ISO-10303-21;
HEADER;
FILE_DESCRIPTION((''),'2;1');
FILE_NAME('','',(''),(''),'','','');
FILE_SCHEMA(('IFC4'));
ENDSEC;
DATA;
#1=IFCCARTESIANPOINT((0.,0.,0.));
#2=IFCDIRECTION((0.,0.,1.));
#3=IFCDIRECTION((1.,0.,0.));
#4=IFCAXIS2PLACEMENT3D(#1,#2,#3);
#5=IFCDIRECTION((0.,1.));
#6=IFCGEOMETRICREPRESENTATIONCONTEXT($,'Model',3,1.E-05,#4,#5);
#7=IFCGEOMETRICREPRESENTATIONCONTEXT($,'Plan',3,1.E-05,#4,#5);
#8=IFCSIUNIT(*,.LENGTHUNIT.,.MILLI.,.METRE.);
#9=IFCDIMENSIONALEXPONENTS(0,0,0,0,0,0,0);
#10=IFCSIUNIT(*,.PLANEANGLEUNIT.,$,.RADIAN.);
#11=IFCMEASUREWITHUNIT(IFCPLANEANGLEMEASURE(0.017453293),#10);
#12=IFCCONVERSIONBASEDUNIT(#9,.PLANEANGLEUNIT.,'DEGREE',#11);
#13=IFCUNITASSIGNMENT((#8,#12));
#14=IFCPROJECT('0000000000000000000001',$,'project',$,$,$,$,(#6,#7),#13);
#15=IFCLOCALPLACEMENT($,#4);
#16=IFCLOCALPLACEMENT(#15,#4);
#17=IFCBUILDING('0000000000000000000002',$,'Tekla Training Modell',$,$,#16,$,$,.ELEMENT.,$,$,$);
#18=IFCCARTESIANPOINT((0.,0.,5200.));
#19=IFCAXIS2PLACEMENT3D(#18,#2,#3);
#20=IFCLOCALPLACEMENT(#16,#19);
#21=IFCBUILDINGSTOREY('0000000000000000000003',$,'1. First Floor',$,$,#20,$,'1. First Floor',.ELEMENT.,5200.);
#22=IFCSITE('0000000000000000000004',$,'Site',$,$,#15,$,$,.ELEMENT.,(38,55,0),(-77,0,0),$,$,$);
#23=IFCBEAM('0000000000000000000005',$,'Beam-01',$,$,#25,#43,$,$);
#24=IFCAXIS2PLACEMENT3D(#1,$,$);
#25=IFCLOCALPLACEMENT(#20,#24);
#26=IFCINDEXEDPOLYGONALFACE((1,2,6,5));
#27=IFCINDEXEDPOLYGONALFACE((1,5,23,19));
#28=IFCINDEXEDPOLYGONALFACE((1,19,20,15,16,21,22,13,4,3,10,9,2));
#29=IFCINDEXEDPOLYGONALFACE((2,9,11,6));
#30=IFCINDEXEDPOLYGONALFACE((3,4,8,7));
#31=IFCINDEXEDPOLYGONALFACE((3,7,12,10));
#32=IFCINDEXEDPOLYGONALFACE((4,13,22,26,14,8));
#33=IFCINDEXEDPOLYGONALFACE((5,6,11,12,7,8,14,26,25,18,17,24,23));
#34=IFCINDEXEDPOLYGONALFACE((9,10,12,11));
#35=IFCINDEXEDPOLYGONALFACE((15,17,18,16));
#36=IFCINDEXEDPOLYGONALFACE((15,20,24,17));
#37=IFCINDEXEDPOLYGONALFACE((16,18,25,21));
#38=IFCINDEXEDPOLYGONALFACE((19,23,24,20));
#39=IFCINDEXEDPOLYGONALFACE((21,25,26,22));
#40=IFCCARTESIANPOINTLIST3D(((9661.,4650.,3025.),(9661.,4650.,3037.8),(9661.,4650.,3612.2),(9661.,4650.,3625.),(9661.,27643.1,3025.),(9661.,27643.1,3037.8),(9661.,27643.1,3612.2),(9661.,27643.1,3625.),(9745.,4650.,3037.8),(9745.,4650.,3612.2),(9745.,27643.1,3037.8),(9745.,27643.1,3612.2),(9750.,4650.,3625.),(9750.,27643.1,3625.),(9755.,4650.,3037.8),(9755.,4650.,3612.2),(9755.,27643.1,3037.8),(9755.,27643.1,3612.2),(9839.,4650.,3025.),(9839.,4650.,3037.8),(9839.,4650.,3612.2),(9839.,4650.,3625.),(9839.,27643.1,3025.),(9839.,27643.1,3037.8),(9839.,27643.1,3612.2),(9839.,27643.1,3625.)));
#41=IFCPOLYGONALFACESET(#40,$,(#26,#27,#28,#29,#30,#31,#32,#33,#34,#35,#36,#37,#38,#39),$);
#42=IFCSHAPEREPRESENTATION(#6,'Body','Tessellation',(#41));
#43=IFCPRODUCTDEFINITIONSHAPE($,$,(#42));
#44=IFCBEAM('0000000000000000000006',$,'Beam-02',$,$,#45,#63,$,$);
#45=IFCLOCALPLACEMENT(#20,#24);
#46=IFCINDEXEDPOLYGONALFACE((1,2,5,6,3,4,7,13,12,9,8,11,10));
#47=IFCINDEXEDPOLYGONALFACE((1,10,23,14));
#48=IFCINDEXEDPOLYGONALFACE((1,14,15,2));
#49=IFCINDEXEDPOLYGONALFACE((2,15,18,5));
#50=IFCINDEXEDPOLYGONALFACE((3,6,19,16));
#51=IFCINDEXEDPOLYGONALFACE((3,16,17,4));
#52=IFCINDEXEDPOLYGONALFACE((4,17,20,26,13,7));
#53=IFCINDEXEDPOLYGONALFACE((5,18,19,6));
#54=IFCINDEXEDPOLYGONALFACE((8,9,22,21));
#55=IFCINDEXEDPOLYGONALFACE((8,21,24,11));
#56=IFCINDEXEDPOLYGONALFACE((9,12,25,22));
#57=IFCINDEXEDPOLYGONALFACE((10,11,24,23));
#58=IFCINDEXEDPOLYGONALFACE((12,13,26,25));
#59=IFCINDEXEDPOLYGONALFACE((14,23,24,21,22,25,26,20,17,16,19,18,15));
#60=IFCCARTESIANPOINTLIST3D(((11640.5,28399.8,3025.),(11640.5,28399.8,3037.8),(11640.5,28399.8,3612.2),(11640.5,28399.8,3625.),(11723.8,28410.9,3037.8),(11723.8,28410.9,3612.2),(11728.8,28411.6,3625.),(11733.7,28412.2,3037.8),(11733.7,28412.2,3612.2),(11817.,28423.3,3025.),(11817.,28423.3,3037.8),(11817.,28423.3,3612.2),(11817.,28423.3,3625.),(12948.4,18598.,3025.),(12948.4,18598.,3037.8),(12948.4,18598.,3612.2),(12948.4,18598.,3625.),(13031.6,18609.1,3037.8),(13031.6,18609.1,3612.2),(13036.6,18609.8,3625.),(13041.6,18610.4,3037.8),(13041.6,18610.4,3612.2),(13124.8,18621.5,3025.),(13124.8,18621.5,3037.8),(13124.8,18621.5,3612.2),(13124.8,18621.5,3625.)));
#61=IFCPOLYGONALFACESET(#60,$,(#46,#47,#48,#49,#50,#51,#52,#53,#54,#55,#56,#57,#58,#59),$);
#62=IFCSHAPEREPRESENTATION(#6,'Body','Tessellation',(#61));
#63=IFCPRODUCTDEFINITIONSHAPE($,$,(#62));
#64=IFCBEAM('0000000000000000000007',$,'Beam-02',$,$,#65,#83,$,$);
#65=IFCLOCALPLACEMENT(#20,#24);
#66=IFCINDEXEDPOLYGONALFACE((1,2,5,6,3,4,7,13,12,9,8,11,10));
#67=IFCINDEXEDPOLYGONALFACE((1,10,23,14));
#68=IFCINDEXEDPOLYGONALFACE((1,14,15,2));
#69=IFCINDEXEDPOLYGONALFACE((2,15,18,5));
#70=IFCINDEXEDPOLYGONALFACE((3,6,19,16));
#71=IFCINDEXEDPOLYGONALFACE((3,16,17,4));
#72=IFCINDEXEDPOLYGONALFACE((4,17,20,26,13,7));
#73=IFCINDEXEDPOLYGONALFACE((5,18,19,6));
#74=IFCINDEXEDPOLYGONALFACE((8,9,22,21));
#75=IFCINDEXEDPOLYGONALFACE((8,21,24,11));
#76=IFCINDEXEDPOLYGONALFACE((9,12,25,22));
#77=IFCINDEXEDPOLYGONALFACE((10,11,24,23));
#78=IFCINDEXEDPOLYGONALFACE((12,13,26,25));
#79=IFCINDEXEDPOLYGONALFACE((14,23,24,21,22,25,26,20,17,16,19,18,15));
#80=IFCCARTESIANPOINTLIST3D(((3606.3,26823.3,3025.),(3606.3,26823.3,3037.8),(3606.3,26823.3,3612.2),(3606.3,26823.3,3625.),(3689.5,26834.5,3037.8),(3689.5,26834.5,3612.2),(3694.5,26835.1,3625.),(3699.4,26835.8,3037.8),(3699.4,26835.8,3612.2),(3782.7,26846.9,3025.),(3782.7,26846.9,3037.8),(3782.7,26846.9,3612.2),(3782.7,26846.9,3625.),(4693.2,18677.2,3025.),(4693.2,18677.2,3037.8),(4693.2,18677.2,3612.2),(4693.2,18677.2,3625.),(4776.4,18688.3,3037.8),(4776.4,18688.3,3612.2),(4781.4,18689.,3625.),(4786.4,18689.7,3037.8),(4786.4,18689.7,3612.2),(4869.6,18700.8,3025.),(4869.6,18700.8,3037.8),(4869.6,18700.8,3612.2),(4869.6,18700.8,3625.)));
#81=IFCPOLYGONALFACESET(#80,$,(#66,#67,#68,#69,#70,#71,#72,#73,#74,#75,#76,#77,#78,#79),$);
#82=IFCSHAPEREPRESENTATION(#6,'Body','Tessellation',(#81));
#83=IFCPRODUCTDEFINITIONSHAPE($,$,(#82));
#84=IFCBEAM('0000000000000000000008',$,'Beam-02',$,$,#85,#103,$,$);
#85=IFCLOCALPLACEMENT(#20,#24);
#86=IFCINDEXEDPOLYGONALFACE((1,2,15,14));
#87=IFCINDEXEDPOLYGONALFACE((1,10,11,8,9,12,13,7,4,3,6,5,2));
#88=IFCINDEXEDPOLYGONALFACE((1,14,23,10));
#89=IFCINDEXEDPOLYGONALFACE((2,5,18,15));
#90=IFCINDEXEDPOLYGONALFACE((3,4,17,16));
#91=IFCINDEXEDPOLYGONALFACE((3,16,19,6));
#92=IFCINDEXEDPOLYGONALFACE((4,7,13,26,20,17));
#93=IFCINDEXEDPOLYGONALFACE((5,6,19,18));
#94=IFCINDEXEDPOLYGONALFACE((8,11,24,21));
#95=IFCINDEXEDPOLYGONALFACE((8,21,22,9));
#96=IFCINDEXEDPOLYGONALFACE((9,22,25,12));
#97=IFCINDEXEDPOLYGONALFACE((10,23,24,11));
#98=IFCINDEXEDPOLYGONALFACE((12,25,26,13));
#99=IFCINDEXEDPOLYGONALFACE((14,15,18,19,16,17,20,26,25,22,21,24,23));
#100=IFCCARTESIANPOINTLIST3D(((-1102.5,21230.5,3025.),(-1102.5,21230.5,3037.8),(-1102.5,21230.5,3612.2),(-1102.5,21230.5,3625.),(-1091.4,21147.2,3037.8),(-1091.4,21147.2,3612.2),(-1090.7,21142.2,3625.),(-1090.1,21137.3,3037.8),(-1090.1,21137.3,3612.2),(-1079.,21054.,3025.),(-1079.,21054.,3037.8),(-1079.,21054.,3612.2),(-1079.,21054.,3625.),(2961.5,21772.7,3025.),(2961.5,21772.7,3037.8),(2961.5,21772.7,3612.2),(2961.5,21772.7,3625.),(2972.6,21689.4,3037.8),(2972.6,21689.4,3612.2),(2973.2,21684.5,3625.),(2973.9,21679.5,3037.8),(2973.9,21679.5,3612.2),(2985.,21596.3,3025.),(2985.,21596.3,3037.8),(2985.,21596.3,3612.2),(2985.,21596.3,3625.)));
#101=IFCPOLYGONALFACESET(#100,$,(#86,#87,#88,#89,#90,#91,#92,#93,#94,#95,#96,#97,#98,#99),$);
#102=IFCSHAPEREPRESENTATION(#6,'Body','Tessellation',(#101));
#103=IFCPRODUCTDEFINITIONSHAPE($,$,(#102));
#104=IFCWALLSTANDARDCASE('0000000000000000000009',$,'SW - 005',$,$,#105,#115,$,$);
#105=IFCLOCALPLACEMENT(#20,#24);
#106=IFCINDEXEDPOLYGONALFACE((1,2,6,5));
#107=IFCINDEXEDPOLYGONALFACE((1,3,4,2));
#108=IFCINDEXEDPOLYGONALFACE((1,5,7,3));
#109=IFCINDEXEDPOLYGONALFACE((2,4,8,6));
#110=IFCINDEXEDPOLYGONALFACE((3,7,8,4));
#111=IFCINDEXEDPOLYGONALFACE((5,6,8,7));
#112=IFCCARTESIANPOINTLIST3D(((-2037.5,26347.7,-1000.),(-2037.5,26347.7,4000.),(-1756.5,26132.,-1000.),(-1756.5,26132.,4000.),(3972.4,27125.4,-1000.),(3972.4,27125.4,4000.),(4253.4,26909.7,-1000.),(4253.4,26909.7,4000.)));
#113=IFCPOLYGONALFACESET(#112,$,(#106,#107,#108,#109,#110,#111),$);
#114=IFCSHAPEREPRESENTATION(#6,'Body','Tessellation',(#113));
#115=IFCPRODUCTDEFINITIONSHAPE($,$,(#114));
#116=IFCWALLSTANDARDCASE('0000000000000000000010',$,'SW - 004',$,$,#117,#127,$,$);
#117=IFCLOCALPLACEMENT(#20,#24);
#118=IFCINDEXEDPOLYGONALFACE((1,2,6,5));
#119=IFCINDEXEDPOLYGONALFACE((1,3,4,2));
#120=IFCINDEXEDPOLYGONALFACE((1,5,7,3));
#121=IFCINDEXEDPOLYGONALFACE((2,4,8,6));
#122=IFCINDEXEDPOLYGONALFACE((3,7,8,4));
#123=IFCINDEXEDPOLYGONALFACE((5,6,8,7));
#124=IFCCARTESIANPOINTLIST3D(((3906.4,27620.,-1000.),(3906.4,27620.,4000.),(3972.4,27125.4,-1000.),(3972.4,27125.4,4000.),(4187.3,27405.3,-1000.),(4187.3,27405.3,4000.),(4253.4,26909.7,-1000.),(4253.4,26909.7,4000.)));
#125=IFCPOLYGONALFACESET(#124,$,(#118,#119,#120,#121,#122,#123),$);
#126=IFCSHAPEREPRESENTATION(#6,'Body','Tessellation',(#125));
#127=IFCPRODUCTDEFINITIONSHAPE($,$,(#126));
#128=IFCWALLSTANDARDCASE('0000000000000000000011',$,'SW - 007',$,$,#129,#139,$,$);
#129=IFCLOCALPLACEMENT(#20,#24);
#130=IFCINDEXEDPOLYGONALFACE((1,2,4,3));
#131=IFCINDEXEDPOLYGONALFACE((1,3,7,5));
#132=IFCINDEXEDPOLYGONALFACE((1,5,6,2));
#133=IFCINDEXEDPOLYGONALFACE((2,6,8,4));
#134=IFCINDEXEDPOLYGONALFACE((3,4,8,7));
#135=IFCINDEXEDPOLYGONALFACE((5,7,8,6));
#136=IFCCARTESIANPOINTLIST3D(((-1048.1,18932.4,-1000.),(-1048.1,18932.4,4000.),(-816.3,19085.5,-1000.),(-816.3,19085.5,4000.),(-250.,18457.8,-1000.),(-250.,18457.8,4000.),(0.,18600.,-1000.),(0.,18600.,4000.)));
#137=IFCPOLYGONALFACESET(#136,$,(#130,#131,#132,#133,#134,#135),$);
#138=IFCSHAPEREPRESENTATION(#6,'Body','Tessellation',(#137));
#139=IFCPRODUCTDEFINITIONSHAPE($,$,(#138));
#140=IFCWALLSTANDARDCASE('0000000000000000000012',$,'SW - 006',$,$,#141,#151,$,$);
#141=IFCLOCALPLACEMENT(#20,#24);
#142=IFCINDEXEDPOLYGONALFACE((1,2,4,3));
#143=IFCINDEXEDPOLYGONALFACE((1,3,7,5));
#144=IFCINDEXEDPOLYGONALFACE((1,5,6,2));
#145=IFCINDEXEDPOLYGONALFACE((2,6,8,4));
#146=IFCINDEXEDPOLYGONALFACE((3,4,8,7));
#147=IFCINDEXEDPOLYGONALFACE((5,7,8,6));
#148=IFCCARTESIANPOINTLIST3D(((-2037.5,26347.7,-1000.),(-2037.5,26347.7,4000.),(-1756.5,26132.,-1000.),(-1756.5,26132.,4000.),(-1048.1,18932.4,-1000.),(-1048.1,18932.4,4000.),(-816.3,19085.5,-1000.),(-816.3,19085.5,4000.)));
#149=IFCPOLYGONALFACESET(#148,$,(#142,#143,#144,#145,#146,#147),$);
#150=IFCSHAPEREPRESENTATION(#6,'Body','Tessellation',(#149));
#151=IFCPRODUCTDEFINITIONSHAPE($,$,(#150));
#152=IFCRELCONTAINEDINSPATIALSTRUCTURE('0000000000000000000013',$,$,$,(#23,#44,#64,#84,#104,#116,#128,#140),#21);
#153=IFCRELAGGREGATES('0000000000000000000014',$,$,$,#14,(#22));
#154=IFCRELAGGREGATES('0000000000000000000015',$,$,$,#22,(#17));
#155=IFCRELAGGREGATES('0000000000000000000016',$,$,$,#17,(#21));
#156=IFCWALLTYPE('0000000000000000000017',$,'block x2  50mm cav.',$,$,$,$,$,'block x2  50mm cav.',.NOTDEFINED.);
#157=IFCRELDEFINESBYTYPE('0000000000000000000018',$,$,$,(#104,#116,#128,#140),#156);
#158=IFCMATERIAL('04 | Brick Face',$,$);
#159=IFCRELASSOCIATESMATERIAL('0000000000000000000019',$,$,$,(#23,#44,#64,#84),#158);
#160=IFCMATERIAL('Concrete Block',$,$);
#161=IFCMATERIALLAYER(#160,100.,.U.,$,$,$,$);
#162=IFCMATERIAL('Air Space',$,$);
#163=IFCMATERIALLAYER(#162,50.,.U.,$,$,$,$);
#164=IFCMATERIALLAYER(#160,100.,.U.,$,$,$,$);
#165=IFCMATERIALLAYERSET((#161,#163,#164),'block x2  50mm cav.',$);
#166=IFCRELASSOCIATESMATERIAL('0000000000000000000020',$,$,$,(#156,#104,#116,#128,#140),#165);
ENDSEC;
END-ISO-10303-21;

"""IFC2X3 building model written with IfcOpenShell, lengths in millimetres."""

from ifc_helpers import new_model, entity, si_unit, converted_unit, direction, frame, origin_with_axes, place, context, project, spatial, polyline, outline, extrude, material, layer, layer_set, layer_usage, type_object, element, save


model = new_model("IFC2X3")

# Units and contexts
model_context = context("Model", 3, precision=1e-05, world=origin_with_axes(), true_north=direction((0.0, 1.0)))
plan_context = context("Plan", 3, precision=1e-05, world=origin_with_axes(), true_north=direction((0.0, 1.0)))
ifc_project = project(units=[si_unit("LENGTHUNIT", "METRE", prefix="MILLI"), converted_unit("PLANEANGLEUNIT", "DEGREE", entity("IfcPlaneAngleMeasure", 0.017453293), si_unit("PLANEANGLEUNIT", "RADIAN"), dimensions=[0, 0, 0, 0, 0, 0, 0])], contexts=[model_context, plan_context])

# Site, building, storey
site_placement = place(None, origin_with_axes())
site = spatial("IfcSite", under=ifc_project, at=site_placement, Name="Site", CompositionType="ELEMENT", RefLatitude=(38, 55, 0), RefLongitude=(-77, 0, 0))
building_placement = place(site_placement, origin_with_axes())
building = spatial("IfcBuilding", under=site, at=building_placement, Name="Tekla Training Modell", CompositionType="ELEMENT")
storey_placement = place(building_placement, frame((0.0, 0.0, 5200.0), z_axis=(0.0, 0.0, 1.0), x_axis=(1.0, 0.0, 0.0)))
storey = spatial("IfcBuildingStorey", under=building, at=storey_placement, Name="1. First Floor", LongName="1. First Floor", CompositionType="ELEMENT", Elevation=5200.0)

# Shared definitions
ifc_material_1 = material(Name="04 | Brick Face")

# Beams
beam_1_placement = place(storey_placement, frame((9750.0, 27643.1, 3325.0), z_axis=(0.0, 0.0, 1.0), x_axis=(-1.0, 0.0, 0.0)))
element("IfcBeam", 1, at=beam_1_placement, inside=storey, material=ifc_material_1, Name="Beam-01", context=model_context, shape_type="SweptSolid", body=[
    extrude(outline(polyline([(0.0, 300.0), (-89.0, 300.0), (-89.0, 287.2), (-5.0, 287.2), (-5.0, -287.2), (-89.0, -287.2), (-89.0, -300.0), (89.0, -300.0), (89.0, -287.2), (5.0, -287.2), (5.0, 287.2), (89.0, 287.2), (89.0, 300.0), (0.0, 300.0)])), frame((0.0, 22993.1, 0.0), z_axis=(0.0, -1.0, 0.0), x_axis=(1.0, 0.0, 0.0)), (0.0, 0.0, 1.0), 22993.1),
])
beam_2_placement = place(storey_placement, frame((11728.8, 28411.6, 3325.0), z_axis=(0.0, 0.0, 1.0), x_axis=(-0.991216, -0.132256, 0.0)))
element("IfcBeam", 2, at=beam_2_placement, inside=storey, material=ifc_material_1, Name="Beam-02", context=model_context, shape_type="SweptSolid", body=[
    extrude(outline(polyline([(0.0, 300.0), (-89.0, 300.0), (-89.0, 287.2), (-5.0, 287.2), (-5.0, -287.2), (-89.0, -287.2), (-89.0, -300.0), (89.0, -300.0), (89.0, -287.2), (5.0, -287.2), (5.0, 287.2), (89.0, 287.2), (89.0, 300.0), (0.0, 300.0)])), frame((0.0, 9888.6, 0.0), z_axis=(0.0, -1.0, 0.0), x_axis=(1.0, 0.0, 0.0)), (0.0, 0.0, 1.0), 9888.6),
])
beam_3_placement = place(storey_placement, frame((3694.5, 26835.1, 3325.0), z_axis=(0.0, 0.0, 1.0), x_axis=(-0.991216, -0.132256, 0.0)))
element("IfcBeam", 3, at=beam_3_placement, inside=storey, material=ifc_material_1, Name="Beam-02", context=model_context, shape_type="SweptSolid", body=[
    extrude(outline(polyline([(0.0, 300.0), (-89.0, 300.0), (-89.0, 287.2), (-5.0, 287.2), (-5.0, -287.2), (-89.0, -287.2), (-89.0, -300.0), (89.0, -300.0), (89.0, -287.2), (5.0, -287.2), (5.0, 287.2), (89.0, 287.2), (89.0, 300.0), (0.0, 300.0)])), frame((0.0, 8218.3, 0.0), z_axis=(0.0, -1.0, 0.0), x_axis=(1.0, 0.0, 0.0)), (0.0, 0.0, 1.0), 8218.3),
])
beam_4_placement = place(storey_placement, frame((-1090.7, 21142.2, 3325.0), z_axis=(0.0, 0.0, 1.0), x_axis=(0.132256, -0.991216, 0.0)))
element("IfcBeam", 4, at=beam_4_placement, inside=storey, material=ifc_material_1, Name="Beam-02", context=model_context, shape_type="SweptSolid", body=[
    extrude(outline(polyline([(0.0, 300.0), (-89.0, 300.0), (-89.0, 287.2), (-5.0, 287.2), (-5.0, -287.2), (-89.0, -287.2), (-89.0, -300.0), (89.0, -300.0), (89.0, -287.2), (5.0, -287.2), (5.0, 287.2), (89.0, 287.2), (89.0, 300.0), (0.0, 300.0)])), frame((0.0, 4100.0, 0.0), z_axis=(0.0, -1.0, 0.0), x_axis=(1.0, 0.0, 0.0)), (0.0, 0.0, 1.0), 4100.0),
])

# Walls
ifc_material_2 = material(Name="Concrete Block")
ifc_layer_1 = layer(ifc_material_2, 100.0, ventilated="UNKNOWN")
ifc_material_3 = material(Name="Air Space")
ifc_layer_2 = layer(ifc_material_3, 50.0, ventilated="UNKNOWN")
ifc_layer_3 = layer(ifc_material_2, 100.0, ventilated="UNKNOWN")
ifc_layer_set_1 = layer_set([ifc_layer_1, ifc_layer_2, ifc_layer_3], Name="block x2  50mm cav.")
ifc_layer_usage_1 = layer_usage(ifc_layer_set_1, "AXIS2", "NEGATIVE", 0.0)
wall_type = type_object("IfcWallType", Name="block x2  50mm cav.", ElementType="block x2  50mm cav.", PredefinedType="NOTDEFINED", material=ifc_layer_set_1)
wall_1_placement = place(storey_placement, frame((4253.4, 26909.7, -1000.0), z_axis=(0.0, 0.0, 1.0), x_axis=(-0.991732, -0.12833, 0.0)))
element("IfcWallStandardCase", 5, at=wall_1_placement, inside=storey, type_object=wall_type, material=ifc_layer_usage_1, Name="SW - 005", context=model_context, shape_type="SweptSolid", body=[
    extrude(outline(polyline([(251.0, -250.0), (6311.0, -250.0), (6060.0, 0.0), (0.0, 0.0), (251.0, -250.0)])), origin_with_axes(), (0.0, 0.0, 1.0), 5000.0),
])
ifc_layer_usage_2 = layer_usage(ifc_layer_set_1, "AXIS2", "NEGATIVE", 0.0)
wall_2_placement = place(storey_placement, frame((4187.3, 27405.3, -1000.0), z_axis=(0.0, 0.0, 1.0), x_axis=(0.132257, -0.991215, 0.0)))
element("IfcWallStandardCase", 6, at=wall_2_placement, inside=storey, type_object=wall_type, material=ifc_layer_usage_2, Name="SW - 004", context=model_context, shape_type="SweptSolid", body=[
    extrude(outline(polyline([(-250.0, -250.0), (249.0, -250.0), (500.0, 0.0), (0.0, 0.0), (-250.0, -250.0)])), origin_with_axes(), (0.0, 0.0, 1.0), 5000.0),
])
ifc_layer_usage_3 = layer_usage(ifc_layer_set_1, "AXIS2", "NEGATIVE", 0.0)
wall_3_placement = place(storey_placement, frame((-816.3, 19085.5, -1000.0), z_axis=(0.0, 0.0, 1.0), x_axis=(0.859493, -0.511147, 0.0)))
element("IfcWallStandardCase", 7, at=wall_3_placement, inside=storey, type_object=wall_type, material=ifc_layer_usage_3, Name="SW - 007", context=model_context, shape_type="SweptSolid", body=[
    extrude(outline(polyline([(-121.0, -250.0), (807.6, -250.0), (949.7, 0.0), (0.0, 0.0), (-121.0, -250.0)])), origin_with_axes(), (0.0, 0.0, 1.0), 5000.0),
])
ifc_layer_usage_4 = layer_usage(ifc_layer_set_1, "AXIS2", "NEGATIVE", 0.0)
wall_4_placement = place(storey_placement, frame((-1756.5, 26132.0, -1000.0), z_axis=(0.0, 0.0, 1.0), x_axis=(0.132257, -0.991215, 0.0)))
element("IfcWallStandardCase", 8, at=wall_4_placement, inside=storey, type_object=wall_type, material=ifc_layer_usage_4, Name="SW - 006", context=model_context, shape_type="SweptSolid", body=[
    extrude(outline(polyline([(-251.0, -250.0), (7230.0, -250.0), (7109.0, 0.0), (0.0, 0.0), (-251.0, -250.0)])), origin_with_axes(), (0.0, 0.0, 1.0), 5000.0),
])

save(model, "model.ifc")
